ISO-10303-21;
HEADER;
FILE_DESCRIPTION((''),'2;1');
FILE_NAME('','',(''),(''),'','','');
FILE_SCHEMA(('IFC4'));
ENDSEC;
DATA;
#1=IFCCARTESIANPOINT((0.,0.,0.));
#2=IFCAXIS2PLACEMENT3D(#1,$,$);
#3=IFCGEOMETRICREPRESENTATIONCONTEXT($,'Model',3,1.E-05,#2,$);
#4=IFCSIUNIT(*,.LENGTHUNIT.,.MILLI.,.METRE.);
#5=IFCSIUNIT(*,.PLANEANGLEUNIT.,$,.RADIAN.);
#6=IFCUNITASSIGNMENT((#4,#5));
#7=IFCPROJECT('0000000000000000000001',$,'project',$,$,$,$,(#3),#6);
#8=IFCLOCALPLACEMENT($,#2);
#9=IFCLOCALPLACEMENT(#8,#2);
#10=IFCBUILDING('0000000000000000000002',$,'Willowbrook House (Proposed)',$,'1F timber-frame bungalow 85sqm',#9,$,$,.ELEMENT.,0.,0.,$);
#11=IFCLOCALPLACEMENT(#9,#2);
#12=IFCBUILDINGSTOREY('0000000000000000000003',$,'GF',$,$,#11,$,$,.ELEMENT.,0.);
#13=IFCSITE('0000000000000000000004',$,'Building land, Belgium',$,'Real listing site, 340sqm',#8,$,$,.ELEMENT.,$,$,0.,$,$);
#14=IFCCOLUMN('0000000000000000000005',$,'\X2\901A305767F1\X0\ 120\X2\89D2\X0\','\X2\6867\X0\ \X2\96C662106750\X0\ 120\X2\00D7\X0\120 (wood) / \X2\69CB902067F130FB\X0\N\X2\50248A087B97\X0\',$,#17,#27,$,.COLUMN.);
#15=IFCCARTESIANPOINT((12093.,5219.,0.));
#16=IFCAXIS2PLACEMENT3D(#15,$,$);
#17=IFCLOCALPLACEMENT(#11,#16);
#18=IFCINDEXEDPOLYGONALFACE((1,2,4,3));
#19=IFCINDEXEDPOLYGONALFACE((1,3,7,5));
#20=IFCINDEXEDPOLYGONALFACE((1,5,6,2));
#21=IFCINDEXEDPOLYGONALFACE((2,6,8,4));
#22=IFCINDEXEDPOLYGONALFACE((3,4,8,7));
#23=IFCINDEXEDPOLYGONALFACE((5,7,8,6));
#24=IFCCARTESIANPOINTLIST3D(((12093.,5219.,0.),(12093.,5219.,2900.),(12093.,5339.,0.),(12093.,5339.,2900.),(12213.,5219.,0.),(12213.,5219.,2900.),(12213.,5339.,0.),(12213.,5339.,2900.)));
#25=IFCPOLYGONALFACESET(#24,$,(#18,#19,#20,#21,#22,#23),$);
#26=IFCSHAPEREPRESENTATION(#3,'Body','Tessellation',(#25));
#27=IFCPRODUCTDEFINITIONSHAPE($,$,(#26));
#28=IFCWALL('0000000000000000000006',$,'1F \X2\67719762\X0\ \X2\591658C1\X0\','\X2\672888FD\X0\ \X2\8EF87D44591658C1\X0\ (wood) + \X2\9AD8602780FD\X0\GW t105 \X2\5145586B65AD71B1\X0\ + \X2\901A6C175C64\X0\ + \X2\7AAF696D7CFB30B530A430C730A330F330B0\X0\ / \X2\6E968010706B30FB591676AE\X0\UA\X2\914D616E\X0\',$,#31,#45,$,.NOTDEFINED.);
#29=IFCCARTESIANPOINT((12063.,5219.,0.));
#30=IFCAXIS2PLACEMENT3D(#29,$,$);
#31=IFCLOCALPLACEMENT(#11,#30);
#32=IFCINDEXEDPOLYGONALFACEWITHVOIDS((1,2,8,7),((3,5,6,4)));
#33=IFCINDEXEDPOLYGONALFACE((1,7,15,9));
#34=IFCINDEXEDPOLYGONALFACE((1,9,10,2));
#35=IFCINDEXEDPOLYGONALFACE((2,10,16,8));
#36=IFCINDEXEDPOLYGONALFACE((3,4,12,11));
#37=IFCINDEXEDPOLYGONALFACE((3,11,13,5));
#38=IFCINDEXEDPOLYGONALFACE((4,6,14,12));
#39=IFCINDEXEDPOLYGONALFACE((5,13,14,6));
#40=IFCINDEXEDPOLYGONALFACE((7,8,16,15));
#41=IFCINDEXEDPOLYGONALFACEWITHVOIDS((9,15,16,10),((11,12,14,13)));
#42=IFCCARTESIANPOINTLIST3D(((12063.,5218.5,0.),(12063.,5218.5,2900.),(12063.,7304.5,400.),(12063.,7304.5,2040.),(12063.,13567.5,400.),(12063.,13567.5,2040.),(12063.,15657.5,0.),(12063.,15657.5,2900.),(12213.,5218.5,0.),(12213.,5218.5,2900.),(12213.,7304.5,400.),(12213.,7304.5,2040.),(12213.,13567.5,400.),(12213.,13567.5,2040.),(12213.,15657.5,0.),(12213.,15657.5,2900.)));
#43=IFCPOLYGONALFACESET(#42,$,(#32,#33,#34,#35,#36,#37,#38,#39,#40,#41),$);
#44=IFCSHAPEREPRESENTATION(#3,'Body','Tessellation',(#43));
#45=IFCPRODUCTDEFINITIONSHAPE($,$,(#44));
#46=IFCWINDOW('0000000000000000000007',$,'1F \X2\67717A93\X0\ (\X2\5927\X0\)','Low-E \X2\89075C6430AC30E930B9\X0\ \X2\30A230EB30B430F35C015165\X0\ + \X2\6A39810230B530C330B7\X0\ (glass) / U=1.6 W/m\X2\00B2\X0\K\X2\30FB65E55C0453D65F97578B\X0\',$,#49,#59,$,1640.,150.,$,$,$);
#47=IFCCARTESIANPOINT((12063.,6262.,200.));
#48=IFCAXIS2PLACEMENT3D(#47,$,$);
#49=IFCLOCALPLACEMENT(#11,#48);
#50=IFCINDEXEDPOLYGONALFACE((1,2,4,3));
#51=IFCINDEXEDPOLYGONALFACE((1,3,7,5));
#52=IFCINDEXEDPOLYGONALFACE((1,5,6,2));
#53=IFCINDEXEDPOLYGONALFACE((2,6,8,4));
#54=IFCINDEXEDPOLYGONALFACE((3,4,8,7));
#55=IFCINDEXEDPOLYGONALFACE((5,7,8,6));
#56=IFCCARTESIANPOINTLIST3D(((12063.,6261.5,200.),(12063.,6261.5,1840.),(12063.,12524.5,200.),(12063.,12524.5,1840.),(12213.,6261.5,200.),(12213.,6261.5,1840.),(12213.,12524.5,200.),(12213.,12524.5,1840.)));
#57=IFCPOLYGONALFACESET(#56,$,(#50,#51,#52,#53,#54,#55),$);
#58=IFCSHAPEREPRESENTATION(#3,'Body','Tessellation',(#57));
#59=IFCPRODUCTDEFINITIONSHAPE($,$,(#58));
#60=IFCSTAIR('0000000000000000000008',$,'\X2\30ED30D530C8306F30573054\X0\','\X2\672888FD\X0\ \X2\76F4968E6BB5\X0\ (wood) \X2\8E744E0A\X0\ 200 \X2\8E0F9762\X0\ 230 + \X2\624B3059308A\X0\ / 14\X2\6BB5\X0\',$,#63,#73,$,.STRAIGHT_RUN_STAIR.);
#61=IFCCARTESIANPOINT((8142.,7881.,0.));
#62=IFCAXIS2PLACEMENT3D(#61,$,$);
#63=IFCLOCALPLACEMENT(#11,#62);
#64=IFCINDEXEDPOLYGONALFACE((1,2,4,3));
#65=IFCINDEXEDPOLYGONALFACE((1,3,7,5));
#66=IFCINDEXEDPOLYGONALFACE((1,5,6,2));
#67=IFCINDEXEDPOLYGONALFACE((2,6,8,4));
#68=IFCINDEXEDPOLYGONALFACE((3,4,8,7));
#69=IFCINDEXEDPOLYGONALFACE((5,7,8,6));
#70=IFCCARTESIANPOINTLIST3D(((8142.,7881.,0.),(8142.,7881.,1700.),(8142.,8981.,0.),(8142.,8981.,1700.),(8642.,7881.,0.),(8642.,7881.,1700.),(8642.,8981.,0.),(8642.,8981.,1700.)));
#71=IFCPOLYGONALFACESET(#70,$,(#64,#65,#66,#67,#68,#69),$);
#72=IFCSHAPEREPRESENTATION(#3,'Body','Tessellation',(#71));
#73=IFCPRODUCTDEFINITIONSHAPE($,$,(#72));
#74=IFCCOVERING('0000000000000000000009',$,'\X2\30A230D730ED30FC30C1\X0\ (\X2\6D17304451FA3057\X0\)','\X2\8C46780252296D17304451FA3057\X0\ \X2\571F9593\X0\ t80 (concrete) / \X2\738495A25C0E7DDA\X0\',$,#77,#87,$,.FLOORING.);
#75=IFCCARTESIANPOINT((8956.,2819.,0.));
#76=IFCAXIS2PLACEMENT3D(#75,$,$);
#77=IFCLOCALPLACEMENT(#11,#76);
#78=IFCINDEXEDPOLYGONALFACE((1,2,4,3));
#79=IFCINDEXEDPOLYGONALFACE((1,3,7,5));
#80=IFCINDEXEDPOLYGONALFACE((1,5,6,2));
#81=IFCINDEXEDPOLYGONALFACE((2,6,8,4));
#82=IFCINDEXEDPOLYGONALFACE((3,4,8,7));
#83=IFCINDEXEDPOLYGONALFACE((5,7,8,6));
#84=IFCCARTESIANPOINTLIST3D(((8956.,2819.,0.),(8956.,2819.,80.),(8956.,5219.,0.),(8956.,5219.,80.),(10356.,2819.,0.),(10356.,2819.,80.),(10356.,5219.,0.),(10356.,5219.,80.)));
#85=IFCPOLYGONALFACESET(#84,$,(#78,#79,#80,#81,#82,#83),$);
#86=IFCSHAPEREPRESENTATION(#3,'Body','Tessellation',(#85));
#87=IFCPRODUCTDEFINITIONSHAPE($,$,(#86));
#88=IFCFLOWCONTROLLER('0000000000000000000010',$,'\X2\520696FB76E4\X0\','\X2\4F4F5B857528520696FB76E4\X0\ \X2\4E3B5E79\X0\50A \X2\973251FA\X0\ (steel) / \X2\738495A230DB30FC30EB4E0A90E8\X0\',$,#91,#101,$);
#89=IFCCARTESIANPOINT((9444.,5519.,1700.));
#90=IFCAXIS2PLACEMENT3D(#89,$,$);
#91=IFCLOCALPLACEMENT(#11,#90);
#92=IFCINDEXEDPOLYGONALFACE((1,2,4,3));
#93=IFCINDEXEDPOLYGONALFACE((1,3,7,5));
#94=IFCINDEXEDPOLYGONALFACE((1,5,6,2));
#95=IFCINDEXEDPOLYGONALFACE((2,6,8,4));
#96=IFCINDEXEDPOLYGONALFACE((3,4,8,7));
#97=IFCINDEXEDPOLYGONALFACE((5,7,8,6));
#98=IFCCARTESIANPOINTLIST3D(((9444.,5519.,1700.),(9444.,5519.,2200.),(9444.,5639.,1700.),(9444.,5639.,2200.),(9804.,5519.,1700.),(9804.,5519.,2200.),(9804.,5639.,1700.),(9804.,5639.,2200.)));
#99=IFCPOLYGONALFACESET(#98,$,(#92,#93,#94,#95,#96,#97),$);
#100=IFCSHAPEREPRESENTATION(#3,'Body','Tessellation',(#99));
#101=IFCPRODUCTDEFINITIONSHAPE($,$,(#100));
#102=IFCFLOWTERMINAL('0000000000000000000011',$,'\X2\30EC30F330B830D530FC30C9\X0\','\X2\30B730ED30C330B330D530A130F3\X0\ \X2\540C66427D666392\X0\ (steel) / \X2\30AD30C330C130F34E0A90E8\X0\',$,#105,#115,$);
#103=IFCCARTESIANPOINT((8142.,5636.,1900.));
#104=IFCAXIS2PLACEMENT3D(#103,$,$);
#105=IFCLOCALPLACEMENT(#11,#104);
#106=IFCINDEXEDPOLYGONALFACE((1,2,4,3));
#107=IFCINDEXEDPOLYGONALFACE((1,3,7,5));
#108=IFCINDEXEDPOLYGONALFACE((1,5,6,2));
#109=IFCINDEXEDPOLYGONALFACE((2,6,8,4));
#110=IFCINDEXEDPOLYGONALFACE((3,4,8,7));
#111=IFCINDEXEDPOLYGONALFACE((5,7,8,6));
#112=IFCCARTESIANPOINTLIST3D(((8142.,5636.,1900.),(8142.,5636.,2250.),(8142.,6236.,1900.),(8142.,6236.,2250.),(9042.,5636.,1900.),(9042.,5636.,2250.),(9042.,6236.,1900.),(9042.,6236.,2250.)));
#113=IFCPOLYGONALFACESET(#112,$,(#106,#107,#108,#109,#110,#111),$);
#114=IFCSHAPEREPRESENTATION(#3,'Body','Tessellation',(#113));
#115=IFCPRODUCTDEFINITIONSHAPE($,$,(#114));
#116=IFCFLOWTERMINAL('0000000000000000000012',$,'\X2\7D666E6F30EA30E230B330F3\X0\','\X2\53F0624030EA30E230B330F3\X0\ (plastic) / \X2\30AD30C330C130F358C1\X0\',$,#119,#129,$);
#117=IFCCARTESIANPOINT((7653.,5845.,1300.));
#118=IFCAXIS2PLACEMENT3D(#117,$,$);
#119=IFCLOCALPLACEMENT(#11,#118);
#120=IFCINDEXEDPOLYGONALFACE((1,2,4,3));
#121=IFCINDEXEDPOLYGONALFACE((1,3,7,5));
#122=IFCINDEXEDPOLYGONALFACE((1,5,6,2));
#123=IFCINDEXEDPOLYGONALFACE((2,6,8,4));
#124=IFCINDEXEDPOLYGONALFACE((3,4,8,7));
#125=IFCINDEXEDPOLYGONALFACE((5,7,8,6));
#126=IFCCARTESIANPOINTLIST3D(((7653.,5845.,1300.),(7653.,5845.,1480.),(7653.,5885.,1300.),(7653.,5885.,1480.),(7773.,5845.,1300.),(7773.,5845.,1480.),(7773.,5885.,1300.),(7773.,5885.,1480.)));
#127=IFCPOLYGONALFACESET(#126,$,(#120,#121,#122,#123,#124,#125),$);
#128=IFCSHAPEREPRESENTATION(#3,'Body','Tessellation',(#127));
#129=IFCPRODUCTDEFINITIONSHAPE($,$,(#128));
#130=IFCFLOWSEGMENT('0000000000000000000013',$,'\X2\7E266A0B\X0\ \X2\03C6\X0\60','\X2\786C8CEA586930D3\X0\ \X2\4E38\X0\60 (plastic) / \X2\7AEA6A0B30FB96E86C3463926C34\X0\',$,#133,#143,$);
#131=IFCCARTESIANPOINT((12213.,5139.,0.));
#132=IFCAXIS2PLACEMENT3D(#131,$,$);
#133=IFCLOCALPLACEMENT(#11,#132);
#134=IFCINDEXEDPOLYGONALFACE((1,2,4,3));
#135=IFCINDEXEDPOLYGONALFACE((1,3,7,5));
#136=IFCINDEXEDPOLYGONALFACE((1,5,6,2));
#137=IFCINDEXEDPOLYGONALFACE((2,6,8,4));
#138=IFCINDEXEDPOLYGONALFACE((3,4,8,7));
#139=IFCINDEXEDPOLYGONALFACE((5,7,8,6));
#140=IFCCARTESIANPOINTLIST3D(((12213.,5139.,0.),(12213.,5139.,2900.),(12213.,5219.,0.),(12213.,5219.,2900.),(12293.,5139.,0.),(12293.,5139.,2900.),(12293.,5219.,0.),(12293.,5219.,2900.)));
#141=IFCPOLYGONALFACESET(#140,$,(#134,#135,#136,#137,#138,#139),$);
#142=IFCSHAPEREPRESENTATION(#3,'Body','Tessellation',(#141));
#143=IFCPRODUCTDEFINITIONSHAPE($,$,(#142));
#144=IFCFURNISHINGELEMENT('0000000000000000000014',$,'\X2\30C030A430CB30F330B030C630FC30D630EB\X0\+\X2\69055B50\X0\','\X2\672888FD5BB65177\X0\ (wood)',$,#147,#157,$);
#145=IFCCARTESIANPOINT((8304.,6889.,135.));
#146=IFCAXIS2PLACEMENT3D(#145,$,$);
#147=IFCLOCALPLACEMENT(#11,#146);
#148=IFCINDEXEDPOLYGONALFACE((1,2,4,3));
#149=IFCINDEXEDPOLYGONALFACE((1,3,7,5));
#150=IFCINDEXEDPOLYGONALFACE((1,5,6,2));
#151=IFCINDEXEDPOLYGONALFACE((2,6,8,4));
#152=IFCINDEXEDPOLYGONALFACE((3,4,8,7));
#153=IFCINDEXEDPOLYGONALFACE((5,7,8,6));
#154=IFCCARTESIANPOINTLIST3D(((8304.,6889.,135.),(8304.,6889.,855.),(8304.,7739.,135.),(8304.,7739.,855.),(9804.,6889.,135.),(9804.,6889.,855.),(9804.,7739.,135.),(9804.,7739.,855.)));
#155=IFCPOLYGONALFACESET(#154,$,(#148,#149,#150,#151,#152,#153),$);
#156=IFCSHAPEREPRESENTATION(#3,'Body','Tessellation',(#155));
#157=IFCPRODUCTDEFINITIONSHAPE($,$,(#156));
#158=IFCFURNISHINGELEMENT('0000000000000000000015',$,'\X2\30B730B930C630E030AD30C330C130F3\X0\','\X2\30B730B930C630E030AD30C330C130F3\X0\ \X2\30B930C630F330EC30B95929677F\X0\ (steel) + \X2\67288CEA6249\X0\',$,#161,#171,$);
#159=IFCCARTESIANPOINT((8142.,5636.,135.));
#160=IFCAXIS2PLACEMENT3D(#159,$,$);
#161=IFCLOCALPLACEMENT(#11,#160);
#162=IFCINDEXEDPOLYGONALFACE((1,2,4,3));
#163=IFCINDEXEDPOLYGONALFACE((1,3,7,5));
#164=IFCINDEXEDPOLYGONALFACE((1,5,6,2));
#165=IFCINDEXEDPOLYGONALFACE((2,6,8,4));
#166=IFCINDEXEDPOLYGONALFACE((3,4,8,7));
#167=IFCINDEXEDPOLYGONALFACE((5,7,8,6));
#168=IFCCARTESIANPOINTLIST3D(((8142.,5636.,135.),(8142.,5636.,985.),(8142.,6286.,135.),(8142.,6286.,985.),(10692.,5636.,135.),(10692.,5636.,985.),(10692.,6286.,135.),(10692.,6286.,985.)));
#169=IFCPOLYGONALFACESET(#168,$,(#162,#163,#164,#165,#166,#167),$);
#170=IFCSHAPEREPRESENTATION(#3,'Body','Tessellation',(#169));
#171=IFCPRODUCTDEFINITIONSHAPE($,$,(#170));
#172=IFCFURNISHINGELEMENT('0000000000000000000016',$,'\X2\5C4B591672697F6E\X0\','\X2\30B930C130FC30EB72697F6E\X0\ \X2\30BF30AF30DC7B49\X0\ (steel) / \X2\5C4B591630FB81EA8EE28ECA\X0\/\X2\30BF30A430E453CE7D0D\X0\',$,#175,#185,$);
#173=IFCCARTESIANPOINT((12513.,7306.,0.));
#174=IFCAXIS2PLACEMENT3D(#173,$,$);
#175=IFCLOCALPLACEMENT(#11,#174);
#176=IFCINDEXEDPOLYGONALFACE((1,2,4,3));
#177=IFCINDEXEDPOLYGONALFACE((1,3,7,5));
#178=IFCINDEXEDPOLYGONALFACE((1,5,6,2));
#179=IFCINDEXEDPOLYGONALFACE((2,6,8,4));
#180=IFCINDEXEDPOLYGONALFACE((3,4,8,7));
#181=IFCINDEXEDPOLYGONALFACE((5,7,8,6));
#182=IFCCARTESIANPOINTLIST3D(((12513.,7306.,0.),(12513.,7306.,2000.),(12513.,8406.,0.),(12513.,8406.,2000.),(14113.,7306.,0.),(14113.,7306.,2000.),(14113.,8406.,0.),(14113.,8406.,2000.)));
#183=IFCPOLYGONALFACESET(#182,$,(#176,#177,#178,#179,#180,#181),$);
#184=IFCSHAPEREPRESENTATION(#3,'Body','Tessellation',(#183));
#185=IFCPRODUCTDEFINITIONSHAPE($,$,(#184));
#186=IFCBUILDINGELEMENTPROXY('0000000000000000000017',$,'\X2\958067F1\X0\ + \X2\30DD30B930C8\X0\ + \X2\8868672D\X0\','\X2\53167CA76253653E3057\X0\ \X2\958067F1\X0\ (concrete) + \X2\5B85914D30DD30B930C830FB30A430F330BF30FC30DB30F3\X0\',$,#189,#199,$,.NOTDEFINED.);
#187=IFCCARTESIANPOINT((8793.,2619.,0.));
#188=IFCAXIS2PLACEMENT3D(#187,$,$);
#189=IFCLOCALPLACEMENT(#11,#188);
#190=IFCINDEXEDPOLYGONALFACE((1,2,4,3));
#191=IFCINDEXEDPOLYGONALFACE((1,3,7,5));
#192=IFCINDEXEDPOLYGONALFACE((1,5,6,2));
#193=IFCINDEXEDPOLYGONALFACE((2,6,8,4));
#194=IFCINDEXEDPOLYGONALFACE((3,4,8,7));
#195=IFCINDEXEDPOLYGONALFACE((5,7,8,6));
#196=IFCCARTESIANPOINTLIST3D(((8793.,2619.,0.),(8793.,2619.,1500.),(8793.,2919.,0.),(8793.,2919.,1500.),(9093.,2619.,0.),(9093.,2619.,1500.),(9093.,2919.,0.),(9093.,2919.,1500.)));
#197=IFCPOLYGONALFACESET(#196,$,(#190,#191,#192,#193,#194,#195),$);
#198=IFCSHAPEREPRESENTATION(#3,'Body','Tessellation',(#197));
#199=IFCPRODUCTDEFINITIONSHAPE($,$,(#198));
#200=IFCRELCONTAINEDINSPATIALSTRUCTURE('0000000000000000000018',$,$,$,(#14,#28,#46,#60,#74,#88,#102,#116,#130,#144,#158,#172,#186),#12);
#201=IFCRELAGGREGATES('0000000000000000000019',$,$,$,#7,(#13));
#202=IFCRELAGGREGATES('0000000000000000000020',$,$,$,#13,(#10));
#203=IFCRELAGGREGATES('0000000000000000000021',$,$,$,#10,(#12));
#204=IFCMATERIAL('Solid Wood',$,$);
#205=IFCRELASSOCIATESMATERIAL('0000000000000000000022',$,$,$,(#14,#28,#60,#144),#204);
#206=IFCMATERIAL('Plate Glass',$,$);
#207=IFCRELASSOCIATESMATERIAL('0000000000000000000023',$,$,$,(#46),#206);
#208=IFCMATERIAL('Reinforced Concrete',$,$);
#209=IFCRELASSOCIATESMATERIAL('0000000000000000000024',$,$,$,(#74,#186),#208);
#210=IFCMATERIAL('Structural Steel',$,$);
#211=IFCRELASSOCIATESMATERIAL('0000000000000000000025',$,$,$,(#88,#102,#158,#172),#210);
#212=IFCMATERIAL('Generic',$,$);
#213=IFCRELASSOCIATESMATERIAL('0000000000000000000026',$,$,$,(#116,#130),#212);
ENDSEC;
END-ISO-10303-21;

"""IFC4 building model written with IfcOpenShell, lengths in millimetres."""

from ifc_helpers import new_model, si_unit, frame, frame_2d, origin, place, context, project, spatial, rectangle, extrude, material, element, fill, save


model = new_model("IFC4")

# Units and contexts
model_context = context("Model", 3, precision=1e-05, world=origin())
ifc_project = project(units=[si_unit("LENGTHUNIT", "METRE", prefix="MILLI"), si_unit("PLANEANGLEUNIT", "RADIAN")], contexts=[model_context])

# Site, building, storey
site_placement = place(None, origin())
site = spatial("IfcSite", under=ifc_project, at=site_placement, Name="Building land, Belgium", ObjectType="Real listing site, 340sqm", CompositionType="ELEMENT", RefElevation=0.0)
building_placement = place(site_placement, origin())
building = spatial("IfcBuilding", under=site, at=building_placement, Name="Willowbrook House (Proposed)", ObjectType="1F timber-frame bungalow 85sqm", CompositionType="ELEMENT", ElevationOfRefHeight=0.0, ElevationOfTerrain=0.0)
storey_placement = place(building_placement, origin())
storey = spatial("IfcBuildingStorey", under=building, at=storey_placement, Name="GF", CompositionType="ELEMENT", Elevation=0.0)

# Column
ifc_material_1 = material(Name="Solid Wood")
column_1_placement = place(storey_placement, frame((12093.0, 5219.0, 0.0)))
element("IfcColumn", 1, at=column_1_placement, inside=storey, material=ifc_material_1, Name="通し柱 120角", Description="桧 集成材 120×120 (wood) / 構造柱・N値計算", PredefinedType="COLUMN", context=model_context, shape_type="SweptSolid", body=[
    extrude(rectangle(XDim=120.0, YDim=120.0, at=frame_2d((60.0, 60.0))), frame((12093.0, 5219.0, 0.0)), (0.0, 0.0, 1.0), 2900.0),
])

# Wall, opening, window
wall_1_placement = place(storey_placement, frame((12063.0, 5219.0, 0.0)))
wall_1 = element("IfcWall", 2, at=wall_1_placement, inside=storey, material=ifc_material_1, Name="1F 東面 外壁", Description="木製 軸組外壁 (wood) + 高性能GW t105 充填断熱 + 通気層 + 窯業系サイディング / 準耐火・外皮UA配慮", PredefinedType="NOTDEFINED", context=model_context, shape_type="SweptSolid", body=[
    extrude(rectangle(XDim=150.0, YDim=10439.0, at=frame_2d((75.0, 5219.0))), frame((12063.0, 5219.0, 0.0)), (0.0, 0.0, 1.0), 2900.0),
])
opening_placement = place(storey_placement, frame((12063.0, 6262.0, 200.0)))
opening = element("IfcOpeningElement", 3, at=opening_placement, cuts=wall_1, PredefinedType="NOTDEFINED", context=model_context, shape_type="SweptSolid", body=[
    extrude(rectangle(XDim=150.0, YDim=6263.0, at=frame_2d((75.0, 3131.0))), frame((12063.0, 6262.0, 200.0)), (0.0, 0.0, 1.0), 1640.0),
])
ifc_material_2 = material(Name="Plate Glass")
window_placement = place(storey_placement, frame((12063.0, 6262.0, 200.0)))
window = element("IfcWindow", 4, at=window_placement, inside=storey, material=ifc_material_2, Name="1F 東窓 (大)", Description="Low-E 複層ガラス アルゴン封入 + 樹脂サッシ (glass) / U=1.6 W/m²K・日射取得型", OverallHeight=1640.0, OverallWidth=150.0, context=model_context, shape_type="SweptSolid", body=[
    extrude(rectangle(XDim=150.0, YDim=6263.0, at=frame_2d((75.0, 3131.0))), frame((12063.0, 6262.0, 200.0)), (0.0, 0.0, 1.0), 1640.0),
])
fill(opening, window)

# Stair
stair_placement = place(storey_placement, frame((8142.0, 7881.0, 0.0)))
element("IfcStair", 5, at=stair_placement, inside=storey, material=ifc_material_1, Name="ロフトはしご", Description="木製 直階段 (wood) 蹴上 200 踏面 230 + 手すり / 14段", PredefinedType="STRAIGHT_RUN_STAIR", context=model_context, shape_type="SweptSolid", body=[
    extrude(rectangle(XDim=500.0, YDim=1100.0, at=frame_2d((250.0, 550.0))), frame((8142.0, 7881.0, 0.0)), (0.0, 0.0, 1.0), 1700.0),
])

# Covering
ifc_material_3 = material(Name="Reinforced Concrete")
covering_placement = place(storey_placement, frame((8956.0, 2819.0, 0.0)))
element("IfcCovering", 6, at=covering_placement, inside=storey, material=ifc_material_3, Name="アプローチ (洗い出し)", Description="豆砂利洗い出し 土間 t80 (concrete) / 玄関導線", PredefinedType="FLOORING", context=model_context, shape_type="SweptSolid", body=[
    extrude(rectangle(XDim=1400.0, YDim=2400.0, at=frame_2d((700.0, 1200.0))), frame((8956.0, 2819.0, 0.0)), (0.0, 0.0, 1.0), 80.0),
])

# Flow controller
ifc_material_4 = material(Name="Structural Steel")
flow_controller_placement = place(storey_placement, frame((9444.0, 5519.0, 1700.0)))
element("IfcFlowController", 7, at=flow_controller_placement, inside=storey, material=ifc_material_4, Name="分電盤", Description="住宅用分電盤 主幹50A 露出 (steel) / 玄関ホール上部", context=model_context, shape_type="SweptSolid", body=[
    extrude(rectangle(XDim=360.0, YDim=120.0, at=frame_2d((180.0, 60.0))), frame((9444.0, 5519.0, 1700.0)), (0.0, 0.0, 1.0), 500.0),
])

# Flow terminals
flow_terminal_1_placement = place(storey_placement, frame((8142.0, 5636.0, 1900.0)))
element("IfcFlowTerminal", 8, at=flow_terminal_1_placement, inside=storey, material=ifc_material_4, Name="レンジフード", Description="シロッコファン 同時給排 (steel) / キッチン上部", context=model_context, shape_type="SweptSolid", body=[
    extrude(rectangle(XDim=900.0, YDim=600.0, at=frame_2d((450.0, 300.0))), frame((8142.0, 5636.0, 1900.0)), (0.0, 0.0, 1.0), 350.0),
])
ifc_material_5 = material(Name="Generic")
flow_terminal_2_placement = place(storey_placement, frame((7653.0, 5845.0, 1300.0)))
element("IfcFlowTerminal", 9, at=flow_terminal_2_placement, inside=storey, material=ifc_material_5, Name="給湯リモコン", Description="台所リモコン (plastic) / キッチン壁", context=model_context, shape_type="SweptSolid", body=[
    extrude(rectangle(XDim=120.0, YDim=40.0, at=frame_2d((60.0, 20.0))), frame((7653.0, 5845.0, 1300.0)), (0.0, 0.0, 1.0), 180.0),
])

# Flow segment
flow_segment_placement = place(storey_placement, frame((12213.0, 5139.0, 0.0)))
element("IfcFlowSegment", 10, at=flow_segment_placement, inside=storey, material=ifc_material_5, Name="縦樋 φ60", Description="硬質塩ビ 丸60 (plastic) / 竪樋・雨水排水", context=model_context, shape_type="SweptSolid", body=[
    extrude(rectangle(XDim=80.0, YDim=80.0, at=frame_2d((40.0, 40.0))), frame((12213.0, 5139.0, 0.0)), (0.0, 0.0, 1.0), 2900.0),
])

# Furnishing elements
furnishing_1_placement = place(storey_placement, frame((8304.0, 6889.0, 135.0)))
element("IfcFurnishingElement", 11, at=furnishing_1_placement, inside=storey, material=ifc_material_1, Name="ダイニングテーブル+椅子", Description="木製家具 (wood)", context=model_context, shape_type="SweptSolid", body=[
    extrude(rectangle(XDim=1500.0, YDim=850.0, at=frame_2d((750.0, 425.0))), frame((8304.0, 6889.0, 135.0)), (0.0, 0.0, 1.0), 720.0),
])
furnishing_2_placement = place(storey_placement, frame((8142.0, 5636.0, 135.0)))
element("IfcFurnishingElement", 12, at=furnishing_2_placement, inside=storey, material=ifc_material_4, Name="システムキッチン", Description="システムキッチン ステンレス天板 (steel) + 木質扉", context=model_context, shape_type="SweptSolid", body=[
    extrude(rectangle(XDim=2550.0, YDim=650.0, at=frame_2d((1275.0, 325.0))), frame((8142.0, 5636.0, 135.0)), (0.0, 0.0, 1.0), 850.0),
])
furnishing_3_placement = place(storey_placement, frame((12513.0, 7306.0, 0.0)))
element("IfcFurnishingElement", 13, at=furnishing_3_placement, inside=storey, material=ifc_material_4, Name="屋外物置", Description="スチール物置 タクボ等 (steel) / 屋外・自転車/タイヤ収納", context=model_context, shape_type="SweptSolid", body=[
    extrude(rectangle(XDim=1600.0, YDim=1100.0, at=frame_2d((800.0, 550.0))), frame((12513.0, 7306.0, 0.0)), (0.0, 0.0, 1.0), 2000.0),
])

# Building element proxy
proxy_placement = place(storey_placement, frame((8793.0, 2619.0, 0.0)))
element("IfcBuildingElementProxy", 14, at=proxy_placement, inside=storey, material=ifc_material_3, Name="門柱 + ポスト + 表札", Description="化粧打放し 門柱 (concrete) + 宅配ポスト・インターホン", PredefinedType="NOTDEFINED", context=model_context, shape_type="SweptSolid", body=[
    extrude(rectangle(XDim=300.0, YDim=300.0, at=frame_2d((150.0, 150.0))), frame((8793.0, 2619.0, 0.0)), (0.0, 0.0, 1.0), 1500.0),
])

save(model, "model.ifc")
